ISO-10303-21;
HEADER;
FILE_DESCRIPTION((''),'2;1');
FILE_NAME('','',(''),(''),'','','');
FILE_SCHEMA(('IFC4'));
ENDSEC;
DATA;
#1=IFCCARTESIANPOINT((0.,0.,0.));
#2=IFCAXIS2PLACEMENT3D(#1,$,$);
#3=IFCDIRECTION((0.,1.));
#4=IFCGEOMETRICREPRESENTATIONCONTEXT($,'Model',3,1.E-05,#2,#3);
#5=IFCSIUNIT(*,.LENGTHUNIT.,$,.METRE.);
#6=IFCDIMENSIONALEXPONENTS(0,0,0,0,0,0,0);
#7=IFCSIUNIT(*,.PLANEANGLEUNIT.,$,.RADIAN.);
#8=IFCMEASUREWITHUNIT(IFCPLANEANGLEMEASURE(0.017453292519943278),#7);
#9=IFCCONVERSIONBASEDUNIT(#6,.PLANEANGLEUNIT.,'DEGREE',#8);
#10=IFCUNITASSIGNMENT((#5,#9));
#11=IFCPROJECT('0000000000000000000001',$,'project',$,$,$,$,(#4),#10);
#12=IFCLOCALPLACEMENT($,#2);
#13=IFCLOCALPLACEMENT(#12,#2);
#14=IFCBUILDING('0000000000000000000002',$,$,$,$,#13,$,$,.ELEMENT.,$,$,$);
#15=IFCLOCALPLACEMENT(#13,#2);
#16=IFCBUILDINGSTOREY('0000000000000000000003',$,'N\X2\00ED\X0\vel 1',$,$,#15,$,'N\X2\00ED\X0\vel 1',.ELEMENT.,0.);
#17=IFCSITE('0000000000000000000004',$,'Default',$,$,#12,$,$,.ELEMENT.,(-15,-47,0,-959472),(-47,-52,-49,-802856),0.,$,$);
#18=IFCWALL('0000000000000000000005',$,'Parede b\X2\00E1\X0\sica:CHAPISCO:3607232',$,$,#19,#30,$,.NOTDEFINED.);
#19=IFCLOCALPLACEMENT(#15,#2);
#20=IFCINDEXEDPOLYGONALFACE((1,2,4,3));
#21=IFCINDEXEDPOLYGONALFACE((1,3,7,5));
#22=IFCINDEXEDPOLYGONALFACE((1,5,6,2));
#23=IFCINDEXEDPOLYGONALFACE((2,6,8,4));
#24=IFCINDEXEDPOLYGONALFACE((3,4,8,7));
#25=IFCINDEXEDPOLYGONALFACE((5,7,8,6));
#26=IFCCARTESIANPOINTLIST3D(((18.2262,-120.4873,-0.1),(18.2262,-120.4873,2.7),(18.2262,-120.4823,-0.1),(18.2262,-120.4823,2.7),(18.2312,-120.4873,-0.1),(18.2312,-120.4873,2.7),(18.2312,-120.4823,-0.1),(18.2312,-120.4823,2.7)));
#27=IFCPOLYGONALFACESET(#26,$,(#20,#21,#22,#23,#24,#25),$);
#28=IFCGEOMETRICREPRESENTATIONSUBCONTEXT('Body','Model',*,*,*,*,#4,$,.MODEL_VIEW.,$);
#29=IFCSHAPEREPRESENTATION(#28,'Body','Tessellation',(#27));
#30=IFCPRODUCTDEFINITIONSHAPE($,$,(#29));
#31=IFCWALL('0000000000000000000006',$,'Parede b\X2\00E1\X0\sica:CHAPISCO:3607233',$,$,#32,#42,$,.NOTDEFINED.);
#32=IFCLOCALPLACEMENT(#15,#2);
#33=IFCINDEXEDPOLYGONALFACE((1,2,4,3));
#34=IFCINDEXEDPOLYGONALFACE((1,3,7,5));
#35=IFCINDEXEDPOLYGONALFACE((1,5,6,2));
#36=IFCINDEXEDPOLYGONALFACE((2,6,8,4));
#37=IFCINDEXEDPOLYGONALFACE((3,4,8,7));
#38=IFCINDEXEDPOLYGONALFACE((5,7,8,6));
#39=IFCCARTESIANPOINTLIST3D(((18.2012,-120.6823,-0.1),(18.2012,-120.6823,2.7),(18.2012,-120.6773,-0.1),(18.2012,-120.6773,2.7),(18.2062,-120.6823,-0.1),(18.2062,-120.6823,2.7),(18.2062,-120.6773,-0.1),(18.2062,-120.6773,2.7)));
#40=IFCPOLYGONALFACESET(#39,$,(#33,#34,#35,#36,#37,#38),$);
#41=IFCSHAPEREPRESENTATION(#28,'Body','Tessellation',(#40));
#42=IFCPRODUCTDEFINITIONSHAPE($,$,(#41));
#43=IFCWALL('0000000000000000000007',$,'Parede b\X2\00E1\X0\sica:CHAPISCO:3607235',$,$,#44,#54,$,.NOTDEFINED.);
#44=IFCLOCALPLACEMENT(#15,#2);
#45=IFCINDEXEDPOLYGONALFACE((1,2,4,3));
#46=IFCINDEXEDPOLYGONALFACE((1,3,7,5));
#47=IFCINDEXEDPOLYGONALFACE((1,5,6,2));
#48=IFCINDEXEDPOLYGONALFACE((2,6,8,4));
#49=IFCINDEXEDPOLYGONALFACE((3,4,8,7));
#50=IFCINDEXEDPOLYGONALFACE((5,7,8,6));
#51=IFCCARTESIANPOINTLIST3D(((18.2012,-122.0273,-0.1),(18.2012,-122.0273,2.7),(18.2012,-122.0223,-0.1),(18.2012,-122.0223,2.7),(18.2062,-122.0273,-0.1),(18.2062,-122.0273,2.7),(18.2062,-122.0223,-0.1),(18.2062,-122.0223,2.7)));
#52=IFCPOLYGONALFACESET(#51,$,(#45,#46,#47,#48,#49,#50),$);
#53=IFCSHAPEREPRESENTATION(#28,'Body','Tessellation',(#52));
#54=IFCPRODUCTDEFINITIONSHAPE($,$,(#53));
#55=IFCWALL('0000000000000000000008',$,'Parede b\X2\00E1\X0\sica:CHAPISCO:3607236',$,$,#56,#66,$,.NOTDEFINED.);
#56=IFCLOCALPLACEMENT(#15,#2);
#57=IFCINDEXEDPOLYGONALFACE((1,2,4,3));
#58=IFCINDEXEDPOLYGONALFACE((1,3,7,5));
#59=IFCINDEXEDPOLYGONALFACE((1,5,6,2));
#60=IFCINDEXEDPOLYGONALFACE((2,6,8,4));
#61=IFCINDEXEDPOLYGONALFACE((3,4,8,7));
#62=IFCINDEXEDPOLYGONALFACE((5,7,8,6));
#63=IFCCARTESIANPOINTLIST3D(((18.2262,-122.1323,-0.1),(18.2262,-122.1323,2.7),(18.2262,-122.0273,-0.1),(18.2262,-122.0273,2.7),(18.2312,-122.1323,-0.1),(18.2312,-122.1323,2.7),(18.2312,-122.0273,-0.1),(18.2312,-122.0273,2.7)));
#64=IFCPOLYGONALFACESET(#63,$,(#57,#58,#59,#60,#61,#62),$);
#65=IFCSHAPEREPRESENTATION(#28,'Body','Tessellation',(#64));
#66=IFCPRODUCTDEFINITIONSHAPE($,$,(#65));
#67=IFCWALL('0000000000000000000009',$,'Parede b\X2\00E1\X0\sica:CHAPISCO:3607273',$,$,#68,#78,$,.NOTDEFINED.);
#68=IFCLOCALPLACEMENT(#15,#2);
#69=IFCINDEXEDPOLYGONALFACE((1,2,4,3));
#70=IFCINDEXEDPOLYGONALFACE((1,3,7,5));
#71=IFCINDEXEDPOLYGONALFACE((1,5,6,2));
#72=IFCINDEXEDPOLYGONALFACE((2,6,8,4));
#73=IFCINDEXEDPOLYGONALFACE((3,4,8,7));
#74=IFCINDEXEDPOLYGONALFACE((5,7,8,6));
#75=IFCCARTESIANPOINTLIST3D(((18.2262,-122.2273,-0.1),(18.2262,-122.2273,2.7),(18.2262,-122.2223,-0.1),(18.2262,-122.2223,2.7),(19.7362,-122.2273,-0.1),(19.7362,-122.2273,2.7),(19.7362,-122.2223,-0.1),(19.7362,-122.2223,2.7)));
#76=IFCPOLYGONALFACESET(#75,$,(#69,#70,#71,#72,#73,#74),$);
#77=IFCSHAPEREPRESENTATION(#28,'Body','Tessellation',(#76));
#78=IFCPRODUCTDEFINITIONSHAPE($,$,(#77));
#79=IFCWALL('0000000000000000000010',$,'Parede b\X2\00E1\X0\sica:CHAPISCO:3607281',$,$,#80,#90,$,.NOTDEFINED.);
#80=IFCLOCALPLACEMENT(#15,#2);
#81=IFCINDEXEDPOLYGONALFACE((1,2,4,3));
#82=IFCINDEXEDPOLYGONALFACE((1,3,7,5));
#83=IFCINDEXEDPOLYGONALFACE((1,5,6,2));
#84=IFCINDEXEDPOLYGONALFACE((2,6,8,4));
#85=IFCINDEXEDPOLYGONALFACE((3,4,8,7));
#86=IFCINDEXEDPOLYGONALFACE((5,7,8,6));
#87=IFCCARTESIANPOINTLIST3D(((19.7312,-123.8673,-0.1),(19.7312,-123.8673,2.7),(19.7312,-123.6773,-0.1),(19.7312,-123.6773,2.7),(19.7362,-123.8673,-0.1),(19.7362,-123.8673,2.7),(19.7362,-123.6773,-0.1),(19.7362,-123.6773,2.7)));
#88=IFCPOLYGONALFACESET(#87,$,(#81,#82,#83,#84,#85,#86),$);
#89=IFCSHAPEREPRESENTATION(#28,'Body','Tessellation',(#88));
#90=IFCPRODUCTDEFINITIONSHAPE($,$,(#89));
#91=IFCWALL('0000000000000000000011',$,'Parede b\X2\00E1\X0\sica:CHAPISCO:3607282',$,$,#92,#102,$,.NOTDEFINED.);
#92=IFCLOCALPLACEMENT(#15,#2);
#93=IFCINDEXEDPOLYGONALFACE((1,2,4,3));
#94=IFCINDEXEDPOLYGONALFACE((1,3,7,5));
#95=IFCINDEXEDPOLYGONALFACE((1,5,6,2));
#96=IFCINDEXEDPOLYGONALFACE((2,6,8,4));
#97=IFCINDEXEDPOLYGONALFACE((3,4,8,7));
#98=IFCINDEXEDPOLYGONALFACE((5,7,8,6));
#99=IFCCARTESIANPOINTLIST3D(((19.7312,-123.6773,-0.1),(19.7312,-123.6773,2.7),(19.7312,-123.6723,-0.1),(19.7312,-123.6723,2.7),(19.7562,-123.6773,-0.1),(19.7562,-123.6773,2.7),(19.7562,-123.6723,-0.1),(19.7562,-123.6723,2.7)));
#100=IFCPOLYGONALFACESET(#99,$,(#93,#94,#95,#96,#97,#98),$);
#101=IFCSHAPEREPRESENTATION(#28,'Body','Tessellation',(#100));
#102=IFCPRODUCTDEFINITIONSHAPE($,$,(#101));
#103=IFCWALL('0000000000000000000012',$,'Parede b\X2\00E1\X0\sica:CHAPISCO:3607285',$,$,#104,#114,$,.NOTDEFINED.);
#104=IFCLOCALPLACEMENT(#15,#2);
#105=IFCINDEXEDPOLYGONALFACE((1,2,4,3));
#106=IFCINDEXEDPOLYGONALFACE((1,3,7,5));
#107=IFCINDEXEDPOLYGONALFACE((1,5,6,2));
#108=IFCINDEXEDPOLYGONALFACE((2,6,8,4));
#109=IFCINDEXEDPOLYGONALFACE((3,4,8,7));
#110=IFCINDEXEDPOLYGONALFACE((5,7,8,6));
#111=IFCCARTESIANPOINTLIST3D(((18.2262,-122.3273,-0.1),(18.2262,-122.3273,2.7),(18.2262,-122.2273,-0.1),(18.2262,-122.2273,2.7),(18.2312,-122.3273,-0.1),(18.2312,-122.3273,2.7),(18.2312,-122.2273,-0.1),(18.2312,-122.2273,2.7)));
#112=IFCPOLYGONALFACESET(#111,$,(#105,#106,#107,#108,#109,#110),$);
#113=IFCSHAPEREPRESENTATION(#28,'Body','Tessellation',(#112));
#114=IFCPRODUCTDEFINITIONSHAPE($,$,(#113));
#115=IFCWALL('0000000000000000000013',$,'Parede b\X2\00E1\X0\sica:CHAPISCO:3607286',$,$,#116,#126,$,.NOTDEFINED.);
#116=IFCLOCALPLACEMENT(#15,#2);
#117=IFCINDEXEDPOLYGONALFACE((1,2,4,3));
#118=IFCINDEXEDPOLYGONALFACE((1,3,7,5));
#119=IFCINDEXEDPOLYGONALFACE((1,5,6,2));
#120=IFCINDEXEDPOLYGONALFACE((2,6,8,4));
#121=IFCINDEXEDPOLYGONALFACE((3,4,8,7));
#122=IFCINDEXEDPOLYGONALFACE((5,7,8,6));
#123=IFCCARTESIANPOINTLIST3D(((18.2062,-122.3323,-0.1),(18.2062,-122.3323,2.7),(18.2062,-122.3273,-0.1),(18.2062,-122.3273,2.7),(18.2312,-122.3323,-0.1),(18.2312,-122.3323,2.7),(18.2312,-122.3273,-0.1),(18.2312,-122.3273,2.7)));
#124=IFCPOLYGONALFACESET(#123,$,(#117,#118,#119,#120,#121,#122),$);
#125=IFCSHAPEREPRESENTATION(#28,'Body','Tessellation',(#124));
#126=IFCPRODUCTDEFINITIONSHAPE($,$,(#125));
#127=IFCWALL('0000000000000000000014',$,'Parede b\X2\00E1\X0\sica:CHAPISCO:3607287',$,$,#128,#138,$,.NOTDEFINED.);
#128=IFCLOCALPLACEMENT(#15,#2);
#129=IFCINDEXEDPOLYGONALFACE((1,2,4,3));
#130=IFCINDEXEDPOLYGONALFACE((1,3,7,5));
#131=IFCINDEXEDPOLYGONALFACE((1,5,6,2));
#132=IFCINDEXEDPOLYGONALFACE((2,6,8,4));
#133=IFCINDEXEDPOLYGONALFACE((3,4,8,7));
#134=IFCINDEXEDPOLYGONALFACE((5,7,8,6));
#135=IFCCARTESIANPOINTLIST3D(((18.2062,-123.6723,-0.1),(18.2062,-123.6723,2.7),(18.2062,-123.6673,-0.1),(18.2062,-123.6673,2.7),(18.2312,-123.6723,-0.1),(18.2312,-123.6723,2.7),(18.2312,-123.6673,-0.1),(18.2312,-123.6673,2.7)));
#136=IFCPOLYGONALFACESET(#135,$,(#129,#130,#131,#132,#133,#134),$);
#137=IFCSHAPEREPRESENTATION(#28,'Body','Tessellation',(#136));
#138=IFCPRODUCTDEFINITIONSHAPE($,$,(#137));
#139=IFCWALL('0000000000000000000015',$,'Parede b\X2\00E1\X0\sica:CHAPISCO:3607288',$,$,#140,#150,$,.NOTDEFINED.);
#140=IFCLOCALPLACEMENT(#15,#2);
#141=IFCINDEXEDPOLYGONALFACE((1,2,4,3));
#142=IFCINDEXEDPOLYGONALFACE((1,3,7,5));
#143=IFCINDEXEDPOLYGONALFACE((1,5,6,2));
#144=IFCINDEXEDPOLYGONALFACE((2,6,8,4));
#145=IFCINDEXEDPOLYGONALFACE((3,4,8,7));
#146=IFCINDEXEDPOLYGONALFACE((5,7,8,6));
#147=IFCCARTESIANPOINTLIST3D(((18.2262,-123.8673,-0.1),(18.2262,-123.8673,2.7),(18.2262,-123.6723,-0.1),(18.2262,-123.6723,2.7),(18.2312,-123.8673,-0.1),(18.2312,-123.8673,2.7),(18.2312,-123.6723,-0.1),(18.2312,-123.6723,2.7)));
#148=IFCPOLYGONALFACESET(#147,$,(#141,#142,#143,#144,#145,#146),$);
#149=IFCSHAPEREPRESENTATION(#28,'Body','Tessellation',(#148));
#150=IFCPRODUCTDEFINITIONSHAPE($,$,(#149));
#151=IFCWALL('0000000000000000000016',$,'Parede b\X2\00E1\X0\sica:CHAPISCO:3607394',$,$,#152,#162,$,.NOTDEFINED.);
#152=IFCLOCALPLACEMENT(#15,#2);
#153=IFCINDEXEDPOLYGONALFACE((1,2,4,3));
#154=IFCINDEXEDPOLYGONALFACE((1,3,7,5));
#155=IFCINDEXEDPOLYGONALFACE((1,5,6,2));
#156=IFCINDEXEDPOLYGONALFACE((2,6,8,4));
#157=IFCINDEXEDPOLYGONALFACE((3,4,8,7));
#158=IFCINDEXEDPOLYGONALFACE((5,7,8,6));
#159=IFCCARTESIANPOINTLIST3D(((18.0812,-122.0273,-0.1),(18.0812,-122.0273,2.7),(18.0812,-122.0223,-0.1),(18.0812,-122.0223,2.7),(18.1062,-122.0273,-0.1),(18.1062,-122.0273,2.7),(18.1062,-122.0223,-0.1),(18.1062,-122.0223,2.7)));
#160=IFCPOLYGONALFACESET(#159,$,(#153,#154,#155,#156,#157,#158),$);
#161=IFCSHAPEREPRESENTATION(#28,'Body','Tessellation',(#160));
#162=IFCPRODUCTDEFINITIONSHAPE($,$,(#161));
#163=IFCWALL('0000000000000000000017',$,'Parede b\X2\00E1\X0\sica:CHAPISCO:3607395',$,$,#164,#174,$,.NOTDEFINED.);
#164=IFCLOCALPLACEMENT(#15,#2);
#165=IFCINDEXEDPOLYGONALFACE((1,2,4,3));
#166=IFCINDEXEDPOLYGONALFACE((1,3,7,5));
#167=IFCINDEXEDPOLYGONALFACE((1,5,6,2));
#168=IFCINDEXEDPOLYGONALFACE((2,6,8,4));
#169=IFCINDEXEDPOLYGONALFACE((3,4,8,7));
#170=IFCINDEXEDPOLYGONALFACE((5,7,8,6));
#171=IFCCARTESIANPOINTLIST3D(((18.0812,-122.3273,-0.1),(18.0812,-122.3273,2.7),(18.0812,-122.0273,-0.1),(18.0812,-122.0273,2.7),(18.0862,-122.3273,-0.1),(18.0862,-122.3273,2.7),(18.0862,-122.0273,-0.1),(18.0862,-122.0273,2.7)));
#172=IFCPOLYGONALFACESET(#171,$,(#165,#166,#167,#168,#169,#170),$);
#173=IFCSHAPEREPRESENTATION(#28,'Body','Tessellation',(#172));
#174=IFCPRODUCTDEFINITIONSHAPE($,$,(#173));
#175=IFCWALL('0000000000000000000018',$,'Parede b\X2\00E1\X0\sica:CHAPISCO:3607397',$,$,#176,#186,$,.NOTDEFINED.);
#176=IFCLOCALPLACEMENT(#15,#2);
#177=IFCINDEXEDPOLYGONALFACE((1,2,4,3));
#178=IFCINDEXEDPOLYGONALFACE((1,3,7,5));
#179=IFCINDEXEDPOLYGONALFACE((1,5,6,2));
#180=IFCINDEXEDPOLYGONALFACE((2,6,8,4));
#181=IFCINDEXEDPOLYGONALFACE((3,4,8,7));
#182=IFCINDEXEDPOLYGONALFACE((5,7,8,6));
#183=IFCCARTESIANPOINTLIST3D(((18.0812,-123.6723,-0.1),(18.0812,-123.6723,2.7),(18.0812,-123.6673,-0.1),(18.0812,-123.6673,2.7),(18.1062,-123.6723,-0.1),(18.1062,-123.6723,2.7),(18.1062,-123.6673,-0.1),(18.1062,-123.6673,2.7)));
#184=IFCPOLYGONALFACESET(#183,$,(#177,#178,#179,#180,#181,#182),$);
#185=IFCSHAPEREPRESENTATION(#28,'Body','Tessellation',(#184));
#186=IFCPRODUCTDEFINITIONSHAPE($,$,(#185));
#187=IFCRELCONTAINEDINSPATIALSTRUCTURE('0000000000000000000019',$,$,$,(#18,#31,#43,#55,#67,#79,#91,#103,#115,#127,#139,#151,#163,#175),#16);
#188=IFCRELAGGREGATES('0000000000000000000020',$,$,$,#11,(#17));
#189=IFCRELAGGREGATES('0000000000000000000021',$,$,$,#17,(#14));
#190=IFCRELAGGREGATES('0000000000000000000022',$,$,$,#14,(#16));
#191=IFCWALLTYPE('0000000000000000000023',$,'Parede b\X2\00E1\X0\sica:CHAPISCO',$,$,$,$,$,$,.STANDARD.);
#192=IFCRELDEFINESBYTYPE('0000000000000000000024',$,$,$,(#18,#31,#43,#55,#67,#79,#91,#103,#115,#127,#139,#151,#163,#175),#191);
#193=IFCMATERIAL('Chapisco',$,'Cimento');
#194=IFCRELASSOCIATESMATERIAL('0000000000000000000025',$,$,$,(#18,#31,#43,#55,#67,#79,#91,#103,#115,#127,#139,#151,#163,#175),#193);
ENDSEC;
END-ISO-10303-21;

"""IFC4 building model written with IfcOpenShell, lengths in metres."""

from ifc_helpers import new_model, entity, si_unit, converted_unit, direction, frame, origin, place, context, subcontext, project, spatial, indexed_curve, outline, extrude, material, type_object, element, save


model = new_model("IFC4")

# Units and contexts
model_context = context("Model", 3, precision=1e-05, world=origin(), true_north=direction((0.0, 1.0)))
body_context = subcontext(model_context, "Body", "Model", "MODEL_VIEW")
ifc_project = project(units=[si_unit("LENGTHUNIT", "METRE"), converted_unit("PLANEANGLEUNIT", "DEGREE", entity("IfcPlaneAngleMeasure", 0.017453292519943278), si_unit("PLANEANGLEUNIT", "RADIAN"), dimensions=[0, 0, 0, 0, 0, 0, 0])], contexts=[model_context])

# Site, building, storey
site_placement = place(None, origin())
site = spatial("IfcSite", under=ifc_project, at=site_placement, Name="Default", CompositionType="ELEMENT", RefLatitude=(-15, -47, 0, -959472), RefLongitude=(-47, -52, -49, -802856), RefElevation=0.0)
building_placement = place(site_placement, origin())
building = spatial("IfcBuilding", under=site, at=building_placement, CompositionType="ELEMENT")
storey_placement = place(building_placement, origin())
storey = spatial("IfcBuildingStorey", under=building, at=storey_placement, Name="Nível 1", LongName="Nível 1", CompositionType="ELEMENT", Elevation=0.0)

# Walls
ifc_material_1 = material(Name="Chapisco", Category="Cimento")
wall_type_1 = type_object("IfcWallType", Name="Parede básica:CHAPISCO", PredefinedType="STANDARD")
wall_1_placement = place(storey_placement, frame((18.2287, -120.4873, -0.1), z_axis=(0.0, 0.0, 1.0), x_axis=(0.0, 1.0, 0.0)))
element("IfcWall", 1, at=wall_1_placement, inside=storey, type_object=wall_type_1, material=ifc_material_1, Name="Parede básica:CHAPISCO:3607232", PredefinedType="NOTDEFINED", context=body_context, shape_type="SweptSolid", body=[
    extrude(outline(indexed_curve([(0.005, 0.0025), (0.0, 0.0025), (0.0, -0.0025), (0.005, -0.0025), (0.005, 0.0025)], self_intersect=False)), origin(), (0.0, 0.0, 1.0), 2.8),
])
wall_2_placement = place(storey_placement, frame((18.2012, -120.6798, -0.1)))
element("IfcWall", 2, at=wall_2_placement, inside=storey, type_object=wall_type_1, material=ifc_material_1, Name="Parede básica:CHAPISCO:3607233", PredefinedType="NOTDEFINED", context=body_context, shape_type="SweptSolid", body=[
    extrude(outline(indexed_curve([(0.005, 0.0025), (0.0, 0.0025), (0.0, -0.0025), (0.005, -0.0025), (0.005, 0.0025)], self_intersect=False)), origin(), (0.0, 0.0, 1.0), 2.8),
])
wall_3_placement = place(storey_placement, frame((18.2062, -122.0248, -0.1), z_axis=(0.0, 0.0, 1.0), x_axis=(-1.0, 0.0, 0.0)))
element("IfcWall", 3, at=wall_3_placement, inside=storey, type_object=wall_type_1, material=ifc_material_1, Name="Parede básica:CHAPISCO:3607235", PredefinedType="NOTDEFINED", context=body_context, shape_type="SweptSolid", body=[
    extrude(outline(indexed_curve([(0.005, 0.0025), (0.0, 0.0025), (0.0, -0.0025), (0.005, -0.0025), (0.005, 0.0025)], self_intersect=False)), origin(), (0.0, 0.0, 1.0), 2.8),
])
wall_4_placement = place(storey_placement, frame((18.2287, -122.1323, -0.1), z_axis=(0.0, 0.0, 1.0), x_axis=(0.0, 1.0, 0.0)))
element("IfcWall", 4, at=wall_4_placement, inside=storey, type_object=wall_type_1, material=ifc_material_1, Name="Parede básica:CHAPISCO:3607236", PredefinedType="NOTDEFINED", context=body_context, shape_type="SweptSolid", body=[
    extrude(outline(indexed_curve([(0.105, 0.0025), (0.0, 0.0025), (0.0, -0.0025), (0.105, -0.0025), (0.105, 0.0025)], self_intersect=False)), origin(), (0.0, 0.0, 1.0), 2.8),
])
wall_5_placement = place(storey_placement, frame((18.2262, -122.2248, -0.1)))
element("IfcWall", 5, at=wall_5_placement, inside=storey, type_object=wall_type_1, material=ifc_material_1, Name="Parede básica:CHAPISCO:3607273", PredefinedType="NOTDEFINED", context=body_context, shape_type="SweptSolid", body=[
    extrude(outline(indexed_curve([(1.51, 0.0025), (0.0, 0.0025), (0.0, -0.0025), (1.51, -0.0025), (1.51, 0.0025)], self_intersect=False)), origin(), (0.0, 0.0, 1.0), 2.8),
])
wall_6_placement = place(storey_placement, frame((19.7337, -123.8673, -0.1), z_axis=(0.0, 0.0, 1.0), x_axis=(0.0, 1.0, 0.0)))
element("IfcWall", 6, at=wall_6_placement, inside=storey, type_object=wall_type_1, material=ifc_material_1, Name="Parede básica:CHAPISCO:3607281", PredefinedType="NOTDEFINED", context=body_context, shape_type="SweptSolid", body=[
    extrude(outline(indexed_curve([(0.19, 0.0025), (0.0, 0.0025), (0.0, -0.0025), (0.19, -0.0025), (0.19, 0.0025)], self_intersect=False)), origin(), (0.0, 0.0, 1.0), 2.8),
])
wall_7_placement = place(storey_placement, frame((19.7312, -123.6748, -0.1)))
element("IfcWall", 7, at=wall_7_placement, inside=storey, type_object=wall_type_1, material=ifc_material_1, Name="Parede básica:CHAPISCO:3607282", PredefinedType="NOTDEFINED", context=body_context, shape_type="SweptSolid", body=[
    extrude(outline(indexed_curve([(0.025, 0.0025), (0.0, 0.0025), (0.0, -0.0025), (0.025, -0.0025), (0.025, 0.0025)], self_intersect=False)), origin(), (0.0, 0.0, 1.0), 2.8),
])
wall_8_placement = place(storey_placement, frame((18.2287, -122.2273, -0.1), z_axis=(0.0, 0.0, 1.0), x_axis=(0.0, -1.0, 0.0)))
element("IfcWall", 8, at=wall_8_placement, inside=storey, type_object=wall_type_1, material=ifc_material_1, Name="Parede básica:CHAPISCO:3607285", PredefinedType="NOTDEFINED", context=body_context, shape_type="SweptSolid", body=[
    extrude(outline(indexed_curve([(0.1, 0.0025), (0.0, 0.0025), (0.0, -0.0025), (0.1, -0.0025), (0.1, 0.0025)], self_intersect=False)), origin(), (0.0, 0.0, 1.0), 2.8),
])
wall_9_placement = place(storey_placement, frame((18.2312, -122.3298, -0.1), z_axis=(0.0, 0.0, 1.0), x_axis=(-1.0, 0.0, 0.0)))
element("IfcWall", 9, at=wall_9_placement, inside=storey, type_object=wall_type_1, material=ifc_material_1, Name="Parede básica:CHAPISCO:3607286", PredefinedType="NOTDEFINED", context=body_context, shape_type="SweptSolid", body=[
    extrude(outline(indexed_curve([(0.025, 0.0025), (0.0, 0.0025), (0.0, -0.0025), (0.025, -0.0025), (0.025, 0.0025)], self_intersect=False)), origin(), (0.0, 0.0, 1.0), 2.8),
])
wall_10_placement = place(storey_placement, frame((18.2062, -123.6698, -0.1)))
element("IfcWall", 10, at=wall_10_placement, inside=storey, type_object=wall_type_1, material=ifc_material_1, Name="Parede básica:CHAPISCO:3607287", PredefinedType="NOTDEFINED", context=body_context, shape_type="SweptSolid", body=[
    extrude(outline(indexed_curve([(0.025, 0.0025), (0.0, 0.0025), (0.0, -0.0025), (0.025, -0.0025), (0.025, 0.0025)], self_intersect=False)), origin(), (0.0, 0.0, 1.0), 2.8),
])
wall_11_placement = place(storey_placement, frame((18.2287, -123.6723, -0.1), z_axis=(0.0, 0.0, 1.0), x_axis=(0.0, -1.0, 0.0)))
element("IfcWall", 11, at=wall_11_placement, inside=storey, type_object=wall_type_1, material=ifc_material_1, Name="Parede básica:CHAPISCO:3607288", PredefinedType="NOTDEFINED", context=body_context, shape_type="SweptSolid", body=[
    extrude(outline(indexed_curve([(0.195, 0.0025), (0.0, 0.0025), (0.0, -0.0025), (0.195, -0.0025), (0.195, 0.0025)], self_intersect=False)), origin(), (0.0, 0.0, 1.0), 2.8),
])
wall_12_placement = place(storey_placement, frame((18.1062, -122.0248, -0.1), z_axis=(0.0, 0.0, 1.0), x_axis=(-1.0, 0.0, 0.0)))
element("IfcWall", 12, at=wall_12_placement, inside=storey, type_object=wall_type_1, material=ifc_material_1, Name="Parede básica:CHAPISCO:3607394", PredefinedType="NOTDEFINED", context=body_context, shape_type="SweptSolid", body=[
    extrude(outline(indexed_curve([(0.025, 0.0025), (0.0, 0.0025), (0.0, -0.0025), (0.025, -0.0025), (0.025, 0.0025)], self_intersect=False)), origin(), (0.0, 0.0, 1.0), 2.8),
])
wall_13_placement = place(storey_placement, frame((18.0837, -122.0273, -0.1), z_axis=(0.0, 0.0, 1.0), x_axis=(0.0, -1.0, 0.0)))
element("IfcWall", 13, at=wall_13_placement, inside=storey, type_object=wall_type_1, material=ifc_material_1, Name="Parede básica:CHAPISCO:3607395", PredefinedType="NOTDEFINED", context=body_context, shape_type="SweptSolid", body=[
    extrude(outline(indexed_curve([(0.3, 0.0025), (0.0, 0.0025), (0.0, -0.0025), (0.3, -0.0025), (0.3, 0.0025)], self_intersect=False)), origin(), (0.0, 0.0, 1.0), 2.8),
])
wall_14_placement = place(storey_placement, frame((18.1062, -123.6698, -0.1), z_axis=(0.0, 0.0, 1.0), x_axis=(-1.0, 0.0, 0.0)))
element("IfcWall", 14, at=wall_14_placement, inside=storey, type_object=wall_type_1, material=ifc_material_1, Name="Parede básica:CHAPISCO:3607397", PredefinedType="NOTDEFINED", context=body_context, shape_type="SweptSolid", body=[
    extrude(outline(indexed_curve([(0.025, 0.0025), (0.0, 0.0025), (0.0, -0.0025), (0.025, -0.0025), (0.025, 0.0025)], self_intersect=False)), origin(), (0.0, 0.0, 1.0), 2.8),
])

save(model, "model.ifc")
